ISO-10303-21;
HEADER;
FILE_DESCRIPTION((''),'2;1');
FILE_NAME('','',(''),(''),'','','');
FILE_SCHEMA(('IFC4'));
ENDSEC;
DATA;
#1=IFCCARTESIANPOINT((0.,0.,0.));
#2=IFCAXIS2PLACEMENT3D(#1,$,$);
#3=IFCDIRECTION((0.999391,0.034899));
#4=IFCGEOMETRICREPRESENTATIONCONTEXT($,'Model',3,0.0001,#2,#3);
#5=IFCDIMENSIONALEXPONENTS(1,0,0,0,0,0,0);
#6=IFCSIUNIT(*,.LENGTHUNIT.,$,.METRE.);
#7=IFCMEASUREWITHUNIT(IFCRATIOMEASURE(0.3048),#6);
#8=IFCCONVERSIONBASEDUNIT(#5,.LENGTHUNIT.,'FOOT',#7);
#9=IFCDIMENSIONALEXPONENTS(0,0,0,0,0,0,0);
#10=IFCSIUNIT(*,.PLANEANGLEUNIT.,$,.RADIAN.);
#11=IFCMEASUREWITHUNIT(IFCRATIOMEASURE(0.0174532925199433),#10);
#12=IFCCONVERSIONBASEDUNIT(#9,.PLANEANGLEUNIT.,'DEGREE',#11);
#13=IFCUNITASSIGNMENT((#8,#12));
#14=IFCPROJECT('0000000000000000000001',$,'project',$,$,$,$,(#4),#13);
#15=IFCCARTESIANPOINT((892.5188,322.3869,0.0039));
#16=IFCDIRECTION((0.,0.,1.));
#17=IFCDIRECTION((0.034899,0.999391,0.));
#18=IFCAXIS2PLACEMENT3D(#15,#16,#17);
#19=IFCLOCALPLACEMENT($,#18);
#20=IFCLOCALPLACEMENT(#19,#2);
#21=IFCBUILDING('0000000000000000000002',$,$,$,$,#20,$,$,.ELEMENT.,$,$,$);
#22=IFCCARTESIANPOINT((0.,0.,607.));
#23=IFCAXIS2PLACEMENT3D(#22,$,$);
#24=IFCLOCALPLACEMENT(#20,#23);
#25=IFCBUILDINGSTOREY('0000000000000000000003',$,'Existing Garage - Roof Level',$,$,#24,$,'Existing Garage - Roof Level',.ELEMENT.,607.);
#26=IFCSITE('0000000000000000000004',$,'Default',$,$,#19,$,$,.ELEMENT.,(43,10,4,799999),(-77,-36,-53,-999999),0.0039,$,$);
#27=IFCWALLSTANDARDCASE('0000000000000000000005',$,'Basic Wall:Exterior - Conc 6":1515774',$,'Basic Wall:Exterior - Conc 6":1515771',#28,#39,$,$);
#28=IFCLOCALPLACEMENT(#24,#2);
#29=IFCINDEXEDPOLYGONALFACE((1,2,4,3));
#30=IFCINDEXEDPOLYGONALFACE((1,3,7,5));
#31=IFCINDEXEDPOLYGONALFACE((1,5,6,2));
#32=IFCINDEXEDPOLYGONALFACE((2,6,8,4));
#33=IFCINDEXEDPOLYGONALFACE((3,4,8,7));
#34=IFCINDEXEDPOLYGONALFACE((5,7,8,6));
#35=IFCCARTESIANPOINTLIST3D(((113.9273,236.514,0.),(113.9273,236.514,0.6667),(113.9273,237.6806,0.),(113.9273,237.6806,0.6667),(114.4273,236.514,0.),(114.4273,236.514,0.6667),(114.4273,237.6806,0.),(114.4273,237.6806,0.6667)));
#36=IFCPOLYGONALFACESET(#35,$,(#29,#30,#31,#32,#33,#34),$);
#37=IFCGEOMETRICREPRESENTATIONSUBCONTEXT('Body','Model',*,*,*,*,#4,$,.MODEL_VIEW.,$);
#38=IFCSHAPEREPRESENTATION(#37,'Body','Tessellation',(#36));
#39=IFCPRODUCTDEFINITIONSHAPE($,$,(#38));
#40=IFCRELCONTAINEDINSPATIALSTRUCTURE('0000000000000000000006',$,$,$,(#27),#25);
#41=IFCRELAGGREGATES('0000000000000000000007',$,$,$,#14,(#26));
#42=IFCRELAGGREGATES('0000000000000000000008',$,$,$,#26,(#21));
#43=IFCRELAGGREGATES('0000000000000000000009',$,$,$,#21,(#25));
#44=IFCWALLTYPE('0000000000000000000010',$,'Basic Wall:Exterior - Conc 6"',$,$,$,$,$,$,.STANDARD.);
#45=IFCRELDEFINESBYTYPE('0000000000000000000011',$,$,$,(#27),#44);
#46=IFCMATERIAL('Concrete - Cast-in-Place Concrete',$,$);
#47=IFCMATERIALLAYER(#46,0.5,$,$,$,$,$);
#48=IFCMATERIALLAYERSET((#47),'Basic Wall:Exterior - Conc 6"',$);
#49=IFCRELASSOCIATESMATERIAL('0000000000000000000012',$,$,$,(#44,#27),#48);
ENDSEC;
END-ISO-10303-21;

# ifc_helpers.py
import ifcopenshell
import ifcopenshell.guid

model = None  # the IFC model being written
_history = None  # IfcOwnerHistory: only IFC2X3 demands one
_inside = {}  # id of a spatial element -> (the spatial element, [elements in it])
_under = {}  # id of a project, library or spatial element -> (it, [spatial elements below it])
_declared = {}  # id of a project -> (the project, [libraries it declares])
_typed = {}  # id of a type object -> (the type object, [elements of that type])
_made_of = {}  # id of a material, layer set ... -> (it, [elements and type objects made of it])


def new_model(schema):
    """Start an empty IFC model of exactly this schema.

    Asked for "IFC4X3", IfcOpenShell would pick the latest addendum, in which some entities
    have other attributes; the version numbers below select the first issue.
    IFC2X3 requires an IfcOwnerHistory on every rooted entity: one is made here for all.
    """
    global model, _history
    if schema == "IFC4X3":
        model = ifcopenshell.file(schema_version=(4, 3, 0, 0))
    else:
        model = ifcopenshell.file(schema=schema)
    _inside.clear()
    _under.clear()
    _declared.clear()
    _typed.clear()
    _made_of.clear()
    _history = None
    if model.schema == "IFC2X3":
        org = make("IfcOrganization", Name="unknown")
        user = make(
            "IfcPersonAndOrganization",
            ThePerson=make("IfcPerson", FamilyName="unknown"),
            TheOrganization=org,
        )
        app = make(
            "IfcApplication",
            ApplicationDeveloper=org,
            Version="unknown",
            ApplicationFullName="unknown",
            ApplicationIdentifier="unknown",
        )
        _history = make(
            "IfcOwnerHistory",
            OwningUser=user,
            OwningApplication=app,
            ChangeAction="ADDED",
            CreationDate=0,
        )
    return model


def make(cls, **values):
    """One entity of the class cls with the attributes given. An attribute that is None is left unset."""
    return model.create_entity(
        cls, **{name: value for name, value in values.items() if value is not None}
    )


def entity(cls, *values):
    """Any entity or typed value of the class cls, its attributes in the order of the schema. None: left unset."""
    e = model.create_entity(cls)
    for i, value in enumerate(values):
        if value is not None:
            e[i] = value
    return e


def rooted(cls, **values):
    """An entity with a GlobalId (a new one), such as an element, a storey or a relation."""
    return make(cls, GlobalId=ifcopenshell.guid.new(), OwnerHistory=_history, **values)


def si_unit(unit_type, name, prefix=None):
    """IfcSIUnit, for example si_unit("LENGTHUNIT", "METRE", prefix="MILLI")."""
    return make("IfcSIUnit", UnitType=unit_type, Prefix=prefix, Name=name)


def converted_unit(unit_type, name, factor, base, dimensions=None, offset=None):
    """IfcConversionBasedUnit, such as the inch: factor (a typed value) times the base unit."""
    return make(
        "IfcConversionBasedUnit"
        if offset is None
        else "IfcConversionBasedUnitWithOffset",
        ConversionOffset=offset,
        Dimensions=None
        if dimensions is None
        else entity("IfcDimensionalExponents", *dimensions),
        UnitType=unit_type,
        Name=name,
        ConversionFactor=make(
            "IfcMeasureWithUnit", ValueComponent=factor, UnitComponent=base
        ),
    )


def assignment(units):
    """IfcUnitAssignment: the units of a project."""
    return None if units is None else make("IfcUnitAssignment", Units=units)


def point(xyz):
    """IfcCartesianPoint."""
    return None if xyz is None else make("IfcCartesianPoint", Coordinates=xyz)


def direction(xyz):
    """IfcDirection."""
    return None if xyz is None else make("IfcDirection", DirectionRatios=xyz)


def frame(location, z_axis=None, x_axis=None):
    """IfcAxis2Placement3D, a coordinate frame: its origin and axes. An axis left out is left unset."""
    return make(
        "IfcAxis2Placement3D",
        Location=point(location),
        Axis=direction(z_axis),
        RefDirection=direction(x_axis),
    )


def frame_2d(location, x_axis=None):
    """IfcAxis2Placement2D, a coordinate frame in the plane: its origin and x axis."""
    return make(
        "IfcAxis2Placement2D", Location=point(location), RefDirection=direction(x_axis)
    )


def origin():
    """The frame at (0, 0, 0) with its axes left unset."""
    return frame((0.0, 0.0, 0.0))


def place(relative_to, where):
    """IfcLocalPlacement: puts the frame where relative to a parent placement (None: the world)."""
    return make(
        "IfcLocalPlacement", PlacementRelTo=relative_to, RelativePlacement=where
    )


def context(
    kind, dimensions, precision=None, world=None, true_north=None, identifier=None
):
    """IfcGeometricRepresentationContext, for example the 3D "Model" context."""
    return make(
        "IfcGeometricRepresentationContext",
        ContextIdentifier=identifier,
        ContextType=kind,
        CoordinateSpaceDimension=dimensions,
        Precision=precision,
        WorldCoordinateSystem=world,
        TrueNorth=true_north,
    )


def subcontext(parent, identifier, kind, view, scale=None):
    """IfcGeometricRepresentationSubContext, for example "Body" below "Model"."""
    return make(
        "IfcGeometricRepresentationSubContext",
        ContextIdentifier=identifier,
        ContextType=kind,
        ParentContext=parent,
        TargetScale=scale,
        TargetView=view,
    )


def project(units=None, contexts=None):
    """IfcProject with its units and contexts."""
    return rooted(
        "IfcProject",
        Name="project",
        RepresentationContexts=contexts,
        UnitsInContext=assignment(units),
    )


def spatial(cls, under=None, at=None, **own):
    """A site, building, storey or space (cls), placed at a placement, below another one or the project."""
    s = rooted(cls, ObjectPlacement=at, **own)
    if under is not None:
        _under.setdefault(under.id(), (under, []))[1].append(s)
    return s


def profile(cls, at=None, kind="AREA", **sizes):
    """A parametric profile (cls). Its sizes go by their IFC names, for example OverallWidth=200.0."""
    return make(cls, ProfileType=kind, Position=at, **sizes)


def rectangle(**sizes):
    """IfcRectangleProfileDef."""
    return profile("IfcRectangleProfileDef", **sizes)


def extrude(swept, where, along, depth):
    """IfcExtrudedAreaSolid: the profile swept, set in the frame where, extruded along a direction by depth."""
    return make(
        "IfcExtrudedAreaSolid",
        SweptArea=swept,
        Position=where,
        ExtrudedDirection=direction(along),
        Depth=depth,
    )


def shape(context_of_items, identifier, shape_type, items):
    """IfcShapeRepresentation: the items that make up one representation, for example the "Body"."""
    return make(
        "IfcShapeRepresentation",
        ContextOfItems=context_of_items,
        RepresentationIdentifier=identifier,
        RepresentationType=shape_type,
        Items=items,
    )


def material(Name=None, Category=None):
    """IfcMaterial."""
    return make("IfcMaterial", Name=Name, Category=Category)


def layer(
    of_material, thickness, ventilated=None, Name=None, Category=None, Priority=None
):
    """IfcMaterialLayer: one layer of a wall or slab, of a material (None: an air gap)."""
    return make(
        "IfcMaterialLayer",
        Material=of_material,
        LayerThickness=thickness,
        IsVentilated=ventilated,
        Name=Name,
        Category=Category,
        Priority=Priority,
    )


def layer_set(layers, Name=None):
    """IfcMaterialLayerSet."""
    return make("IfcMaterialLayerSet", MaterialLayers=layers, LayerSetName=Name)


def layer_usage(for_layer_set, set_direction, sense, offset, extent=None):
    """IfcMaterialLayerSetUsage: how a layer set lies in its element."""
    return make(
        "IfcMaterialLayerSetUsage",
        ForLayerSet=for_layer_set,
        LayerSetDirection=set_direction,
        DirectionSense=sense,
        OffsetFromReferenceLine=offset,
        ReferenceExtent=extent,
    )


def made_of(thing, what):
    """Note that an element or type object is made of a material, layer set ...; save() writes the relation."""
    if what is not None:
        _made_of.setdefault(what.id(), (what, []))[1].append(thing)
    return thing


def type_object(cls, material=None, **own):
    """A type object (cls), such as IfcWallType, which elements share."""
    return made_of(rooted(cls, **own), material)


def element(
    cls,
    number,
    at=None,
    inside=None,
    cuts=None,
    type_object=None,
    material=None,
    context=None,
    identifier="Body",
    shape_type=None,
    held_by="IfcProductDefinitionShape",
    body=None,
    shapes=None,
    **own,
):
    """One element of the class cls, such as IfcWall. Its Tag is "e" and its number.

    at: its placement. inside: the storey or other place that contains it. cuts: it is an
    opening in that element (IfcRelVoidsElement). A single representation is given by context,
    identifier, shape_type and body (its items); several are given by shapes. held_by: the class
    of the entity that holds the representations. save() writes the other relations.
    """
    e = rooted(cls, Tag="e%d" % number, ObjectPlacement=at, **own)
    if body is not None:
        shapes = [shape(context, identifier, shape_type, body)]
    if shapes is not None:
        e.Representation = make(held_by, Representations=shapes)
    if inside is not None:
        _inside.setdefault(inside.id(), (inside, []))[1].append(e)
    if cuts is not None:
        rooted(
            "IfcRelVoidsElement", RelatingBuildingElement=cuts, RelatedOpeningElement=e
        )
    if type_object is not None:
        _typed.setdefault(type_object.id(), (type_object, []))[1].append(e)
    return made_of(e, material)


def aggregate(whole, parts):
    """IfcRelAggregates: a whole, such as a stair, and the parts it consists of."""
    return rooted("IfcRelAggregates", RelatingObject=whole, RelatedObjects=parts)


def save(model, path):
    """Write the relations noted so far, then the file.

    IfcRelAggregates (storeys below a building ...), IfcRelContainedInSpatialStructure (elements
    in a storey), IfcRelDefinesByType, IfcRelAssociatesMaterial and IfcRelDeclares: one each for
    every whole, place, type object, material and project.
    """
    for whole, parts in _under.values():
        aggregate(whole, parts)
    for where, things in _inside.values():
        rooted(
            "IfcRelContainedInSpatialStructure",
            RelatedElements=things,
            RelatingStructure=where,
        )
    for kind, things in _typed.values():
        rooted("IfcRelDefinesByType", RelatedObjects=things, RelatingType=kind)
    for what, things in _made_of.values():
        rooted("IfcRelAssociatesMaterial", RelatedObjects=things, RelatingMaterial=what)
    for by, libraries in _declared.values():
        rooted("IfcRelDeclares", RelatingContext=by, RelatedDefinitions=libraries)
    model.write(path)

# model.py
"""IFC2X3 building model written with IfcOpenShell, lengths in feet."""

from ifc_helpers import new_model, entity, si_unit, converted_unit, direction, frame, frame_2d, origin, place, context, subcontext, project, spatial, rectangle, extrude, material, layer, layer_set, layer_usage, type_object, element, save


model = new_model("IFC2X3")

# Units and contexts
model_context = context("Model", 3, precision=0.0001, world=origin(), true_north=direction((0.999391, 0.034899)))
body_context = subcontext(model_context, "Body", "Model", "MODEL_VIEW")
ifc_project = project(units=[converted_unit("LENGTHUNIT", "FOOT", entity("IfcRatioMeasure", 0.3048), si_unit("LENGTHUNIT", "METRE"), dimensions=[1, 0, 0, 0, 0, 0, 0]), converted_unit("PLANEANGLEUNIT", "DEGREE", entity("IfcRatioMeasure", 0.0174532925199433), si_unit("PLANEANGLEUNIT", "RADIAN"), dimensions=[0, 0, 0, 0, 0, 0, 0])], contexts=[model_context])

# Site, building, storey
site_placement = place(None, frame((892.5188, 322.3869, 0.0039), z_axis=(0.0, 0.0, 1.0), x_axis=(0.034899, 0.999391, 0.0)))
site = spatial("IfcSite", under=ifc_project, at=site_placement, Name="Default", CompositionType="ELEMENT", RefLatitude=(43, 10, 4, 799999), RefLongitude=(-77, -36, -53, -999999), RefElevation=0.0039)
building_placement = place(site_placement, origin())
building = spatial("IfcBuilding", under=site, at=building_placement, CompositionType="ELEMENT")
storey_placement = place(building_placement, frame((0.0, 0.0, 607.0)))
storey = spatial("IfcBuildingStorey", under=building, at=storey_placement, Name="Existing Garage - Roof Level", LongName="Existing Garage - Roof Level", CompositionType="ELEMENT", Elevation=607.0)

# Shared definitions
ifc_material_1 = material(Name="Concrete - Cast-in-Place Concrete")

# Wall
ifc_layer = layer(ifc_material_1, 0.5)
ifc_layer_set = layer_set([ifc_layer], Name="Basic Wall:Exterior - Conc 6\"")
wall_type = type_object("IfcWallType", Name="Basic Wall:Exterior - Conc 6\"", PredefinedType="STANDARD", material=ifc_layer_set)
ifc_layer_usage_1 = layer_usage(ifc_layer_set, "AXIS2", "NEGATIVE", 0.25)
wall_1_placement = place(storey_placement, frame((114.1773, 237.6806, 0.0), z_axis=(0.0, 0.0, 1.0), x_axis=(0.0, -1.0, 0.0)))
element("IfcWallStandardCase", 1, at=wall_1_placement, inside=storey, type_object=wall_type, material=ifc_layer_usage_1, Name="Basic Wall:Exterior - Conc 6\":1515774", ObjectType="Basic Wall:Exterior - Conc 6\":1515771", context=body_context, shape_type="SweptSolid", body=[
    extrude(rectangle(XDim=1.1667, YDim=0.5, at=frame_2d((0.5833, 0.0), x_axis=(-1.0, 0.0))), origin(), (0.0, 0.0, 1.0), 0.6667),
])

save(model, "model.ifc")
